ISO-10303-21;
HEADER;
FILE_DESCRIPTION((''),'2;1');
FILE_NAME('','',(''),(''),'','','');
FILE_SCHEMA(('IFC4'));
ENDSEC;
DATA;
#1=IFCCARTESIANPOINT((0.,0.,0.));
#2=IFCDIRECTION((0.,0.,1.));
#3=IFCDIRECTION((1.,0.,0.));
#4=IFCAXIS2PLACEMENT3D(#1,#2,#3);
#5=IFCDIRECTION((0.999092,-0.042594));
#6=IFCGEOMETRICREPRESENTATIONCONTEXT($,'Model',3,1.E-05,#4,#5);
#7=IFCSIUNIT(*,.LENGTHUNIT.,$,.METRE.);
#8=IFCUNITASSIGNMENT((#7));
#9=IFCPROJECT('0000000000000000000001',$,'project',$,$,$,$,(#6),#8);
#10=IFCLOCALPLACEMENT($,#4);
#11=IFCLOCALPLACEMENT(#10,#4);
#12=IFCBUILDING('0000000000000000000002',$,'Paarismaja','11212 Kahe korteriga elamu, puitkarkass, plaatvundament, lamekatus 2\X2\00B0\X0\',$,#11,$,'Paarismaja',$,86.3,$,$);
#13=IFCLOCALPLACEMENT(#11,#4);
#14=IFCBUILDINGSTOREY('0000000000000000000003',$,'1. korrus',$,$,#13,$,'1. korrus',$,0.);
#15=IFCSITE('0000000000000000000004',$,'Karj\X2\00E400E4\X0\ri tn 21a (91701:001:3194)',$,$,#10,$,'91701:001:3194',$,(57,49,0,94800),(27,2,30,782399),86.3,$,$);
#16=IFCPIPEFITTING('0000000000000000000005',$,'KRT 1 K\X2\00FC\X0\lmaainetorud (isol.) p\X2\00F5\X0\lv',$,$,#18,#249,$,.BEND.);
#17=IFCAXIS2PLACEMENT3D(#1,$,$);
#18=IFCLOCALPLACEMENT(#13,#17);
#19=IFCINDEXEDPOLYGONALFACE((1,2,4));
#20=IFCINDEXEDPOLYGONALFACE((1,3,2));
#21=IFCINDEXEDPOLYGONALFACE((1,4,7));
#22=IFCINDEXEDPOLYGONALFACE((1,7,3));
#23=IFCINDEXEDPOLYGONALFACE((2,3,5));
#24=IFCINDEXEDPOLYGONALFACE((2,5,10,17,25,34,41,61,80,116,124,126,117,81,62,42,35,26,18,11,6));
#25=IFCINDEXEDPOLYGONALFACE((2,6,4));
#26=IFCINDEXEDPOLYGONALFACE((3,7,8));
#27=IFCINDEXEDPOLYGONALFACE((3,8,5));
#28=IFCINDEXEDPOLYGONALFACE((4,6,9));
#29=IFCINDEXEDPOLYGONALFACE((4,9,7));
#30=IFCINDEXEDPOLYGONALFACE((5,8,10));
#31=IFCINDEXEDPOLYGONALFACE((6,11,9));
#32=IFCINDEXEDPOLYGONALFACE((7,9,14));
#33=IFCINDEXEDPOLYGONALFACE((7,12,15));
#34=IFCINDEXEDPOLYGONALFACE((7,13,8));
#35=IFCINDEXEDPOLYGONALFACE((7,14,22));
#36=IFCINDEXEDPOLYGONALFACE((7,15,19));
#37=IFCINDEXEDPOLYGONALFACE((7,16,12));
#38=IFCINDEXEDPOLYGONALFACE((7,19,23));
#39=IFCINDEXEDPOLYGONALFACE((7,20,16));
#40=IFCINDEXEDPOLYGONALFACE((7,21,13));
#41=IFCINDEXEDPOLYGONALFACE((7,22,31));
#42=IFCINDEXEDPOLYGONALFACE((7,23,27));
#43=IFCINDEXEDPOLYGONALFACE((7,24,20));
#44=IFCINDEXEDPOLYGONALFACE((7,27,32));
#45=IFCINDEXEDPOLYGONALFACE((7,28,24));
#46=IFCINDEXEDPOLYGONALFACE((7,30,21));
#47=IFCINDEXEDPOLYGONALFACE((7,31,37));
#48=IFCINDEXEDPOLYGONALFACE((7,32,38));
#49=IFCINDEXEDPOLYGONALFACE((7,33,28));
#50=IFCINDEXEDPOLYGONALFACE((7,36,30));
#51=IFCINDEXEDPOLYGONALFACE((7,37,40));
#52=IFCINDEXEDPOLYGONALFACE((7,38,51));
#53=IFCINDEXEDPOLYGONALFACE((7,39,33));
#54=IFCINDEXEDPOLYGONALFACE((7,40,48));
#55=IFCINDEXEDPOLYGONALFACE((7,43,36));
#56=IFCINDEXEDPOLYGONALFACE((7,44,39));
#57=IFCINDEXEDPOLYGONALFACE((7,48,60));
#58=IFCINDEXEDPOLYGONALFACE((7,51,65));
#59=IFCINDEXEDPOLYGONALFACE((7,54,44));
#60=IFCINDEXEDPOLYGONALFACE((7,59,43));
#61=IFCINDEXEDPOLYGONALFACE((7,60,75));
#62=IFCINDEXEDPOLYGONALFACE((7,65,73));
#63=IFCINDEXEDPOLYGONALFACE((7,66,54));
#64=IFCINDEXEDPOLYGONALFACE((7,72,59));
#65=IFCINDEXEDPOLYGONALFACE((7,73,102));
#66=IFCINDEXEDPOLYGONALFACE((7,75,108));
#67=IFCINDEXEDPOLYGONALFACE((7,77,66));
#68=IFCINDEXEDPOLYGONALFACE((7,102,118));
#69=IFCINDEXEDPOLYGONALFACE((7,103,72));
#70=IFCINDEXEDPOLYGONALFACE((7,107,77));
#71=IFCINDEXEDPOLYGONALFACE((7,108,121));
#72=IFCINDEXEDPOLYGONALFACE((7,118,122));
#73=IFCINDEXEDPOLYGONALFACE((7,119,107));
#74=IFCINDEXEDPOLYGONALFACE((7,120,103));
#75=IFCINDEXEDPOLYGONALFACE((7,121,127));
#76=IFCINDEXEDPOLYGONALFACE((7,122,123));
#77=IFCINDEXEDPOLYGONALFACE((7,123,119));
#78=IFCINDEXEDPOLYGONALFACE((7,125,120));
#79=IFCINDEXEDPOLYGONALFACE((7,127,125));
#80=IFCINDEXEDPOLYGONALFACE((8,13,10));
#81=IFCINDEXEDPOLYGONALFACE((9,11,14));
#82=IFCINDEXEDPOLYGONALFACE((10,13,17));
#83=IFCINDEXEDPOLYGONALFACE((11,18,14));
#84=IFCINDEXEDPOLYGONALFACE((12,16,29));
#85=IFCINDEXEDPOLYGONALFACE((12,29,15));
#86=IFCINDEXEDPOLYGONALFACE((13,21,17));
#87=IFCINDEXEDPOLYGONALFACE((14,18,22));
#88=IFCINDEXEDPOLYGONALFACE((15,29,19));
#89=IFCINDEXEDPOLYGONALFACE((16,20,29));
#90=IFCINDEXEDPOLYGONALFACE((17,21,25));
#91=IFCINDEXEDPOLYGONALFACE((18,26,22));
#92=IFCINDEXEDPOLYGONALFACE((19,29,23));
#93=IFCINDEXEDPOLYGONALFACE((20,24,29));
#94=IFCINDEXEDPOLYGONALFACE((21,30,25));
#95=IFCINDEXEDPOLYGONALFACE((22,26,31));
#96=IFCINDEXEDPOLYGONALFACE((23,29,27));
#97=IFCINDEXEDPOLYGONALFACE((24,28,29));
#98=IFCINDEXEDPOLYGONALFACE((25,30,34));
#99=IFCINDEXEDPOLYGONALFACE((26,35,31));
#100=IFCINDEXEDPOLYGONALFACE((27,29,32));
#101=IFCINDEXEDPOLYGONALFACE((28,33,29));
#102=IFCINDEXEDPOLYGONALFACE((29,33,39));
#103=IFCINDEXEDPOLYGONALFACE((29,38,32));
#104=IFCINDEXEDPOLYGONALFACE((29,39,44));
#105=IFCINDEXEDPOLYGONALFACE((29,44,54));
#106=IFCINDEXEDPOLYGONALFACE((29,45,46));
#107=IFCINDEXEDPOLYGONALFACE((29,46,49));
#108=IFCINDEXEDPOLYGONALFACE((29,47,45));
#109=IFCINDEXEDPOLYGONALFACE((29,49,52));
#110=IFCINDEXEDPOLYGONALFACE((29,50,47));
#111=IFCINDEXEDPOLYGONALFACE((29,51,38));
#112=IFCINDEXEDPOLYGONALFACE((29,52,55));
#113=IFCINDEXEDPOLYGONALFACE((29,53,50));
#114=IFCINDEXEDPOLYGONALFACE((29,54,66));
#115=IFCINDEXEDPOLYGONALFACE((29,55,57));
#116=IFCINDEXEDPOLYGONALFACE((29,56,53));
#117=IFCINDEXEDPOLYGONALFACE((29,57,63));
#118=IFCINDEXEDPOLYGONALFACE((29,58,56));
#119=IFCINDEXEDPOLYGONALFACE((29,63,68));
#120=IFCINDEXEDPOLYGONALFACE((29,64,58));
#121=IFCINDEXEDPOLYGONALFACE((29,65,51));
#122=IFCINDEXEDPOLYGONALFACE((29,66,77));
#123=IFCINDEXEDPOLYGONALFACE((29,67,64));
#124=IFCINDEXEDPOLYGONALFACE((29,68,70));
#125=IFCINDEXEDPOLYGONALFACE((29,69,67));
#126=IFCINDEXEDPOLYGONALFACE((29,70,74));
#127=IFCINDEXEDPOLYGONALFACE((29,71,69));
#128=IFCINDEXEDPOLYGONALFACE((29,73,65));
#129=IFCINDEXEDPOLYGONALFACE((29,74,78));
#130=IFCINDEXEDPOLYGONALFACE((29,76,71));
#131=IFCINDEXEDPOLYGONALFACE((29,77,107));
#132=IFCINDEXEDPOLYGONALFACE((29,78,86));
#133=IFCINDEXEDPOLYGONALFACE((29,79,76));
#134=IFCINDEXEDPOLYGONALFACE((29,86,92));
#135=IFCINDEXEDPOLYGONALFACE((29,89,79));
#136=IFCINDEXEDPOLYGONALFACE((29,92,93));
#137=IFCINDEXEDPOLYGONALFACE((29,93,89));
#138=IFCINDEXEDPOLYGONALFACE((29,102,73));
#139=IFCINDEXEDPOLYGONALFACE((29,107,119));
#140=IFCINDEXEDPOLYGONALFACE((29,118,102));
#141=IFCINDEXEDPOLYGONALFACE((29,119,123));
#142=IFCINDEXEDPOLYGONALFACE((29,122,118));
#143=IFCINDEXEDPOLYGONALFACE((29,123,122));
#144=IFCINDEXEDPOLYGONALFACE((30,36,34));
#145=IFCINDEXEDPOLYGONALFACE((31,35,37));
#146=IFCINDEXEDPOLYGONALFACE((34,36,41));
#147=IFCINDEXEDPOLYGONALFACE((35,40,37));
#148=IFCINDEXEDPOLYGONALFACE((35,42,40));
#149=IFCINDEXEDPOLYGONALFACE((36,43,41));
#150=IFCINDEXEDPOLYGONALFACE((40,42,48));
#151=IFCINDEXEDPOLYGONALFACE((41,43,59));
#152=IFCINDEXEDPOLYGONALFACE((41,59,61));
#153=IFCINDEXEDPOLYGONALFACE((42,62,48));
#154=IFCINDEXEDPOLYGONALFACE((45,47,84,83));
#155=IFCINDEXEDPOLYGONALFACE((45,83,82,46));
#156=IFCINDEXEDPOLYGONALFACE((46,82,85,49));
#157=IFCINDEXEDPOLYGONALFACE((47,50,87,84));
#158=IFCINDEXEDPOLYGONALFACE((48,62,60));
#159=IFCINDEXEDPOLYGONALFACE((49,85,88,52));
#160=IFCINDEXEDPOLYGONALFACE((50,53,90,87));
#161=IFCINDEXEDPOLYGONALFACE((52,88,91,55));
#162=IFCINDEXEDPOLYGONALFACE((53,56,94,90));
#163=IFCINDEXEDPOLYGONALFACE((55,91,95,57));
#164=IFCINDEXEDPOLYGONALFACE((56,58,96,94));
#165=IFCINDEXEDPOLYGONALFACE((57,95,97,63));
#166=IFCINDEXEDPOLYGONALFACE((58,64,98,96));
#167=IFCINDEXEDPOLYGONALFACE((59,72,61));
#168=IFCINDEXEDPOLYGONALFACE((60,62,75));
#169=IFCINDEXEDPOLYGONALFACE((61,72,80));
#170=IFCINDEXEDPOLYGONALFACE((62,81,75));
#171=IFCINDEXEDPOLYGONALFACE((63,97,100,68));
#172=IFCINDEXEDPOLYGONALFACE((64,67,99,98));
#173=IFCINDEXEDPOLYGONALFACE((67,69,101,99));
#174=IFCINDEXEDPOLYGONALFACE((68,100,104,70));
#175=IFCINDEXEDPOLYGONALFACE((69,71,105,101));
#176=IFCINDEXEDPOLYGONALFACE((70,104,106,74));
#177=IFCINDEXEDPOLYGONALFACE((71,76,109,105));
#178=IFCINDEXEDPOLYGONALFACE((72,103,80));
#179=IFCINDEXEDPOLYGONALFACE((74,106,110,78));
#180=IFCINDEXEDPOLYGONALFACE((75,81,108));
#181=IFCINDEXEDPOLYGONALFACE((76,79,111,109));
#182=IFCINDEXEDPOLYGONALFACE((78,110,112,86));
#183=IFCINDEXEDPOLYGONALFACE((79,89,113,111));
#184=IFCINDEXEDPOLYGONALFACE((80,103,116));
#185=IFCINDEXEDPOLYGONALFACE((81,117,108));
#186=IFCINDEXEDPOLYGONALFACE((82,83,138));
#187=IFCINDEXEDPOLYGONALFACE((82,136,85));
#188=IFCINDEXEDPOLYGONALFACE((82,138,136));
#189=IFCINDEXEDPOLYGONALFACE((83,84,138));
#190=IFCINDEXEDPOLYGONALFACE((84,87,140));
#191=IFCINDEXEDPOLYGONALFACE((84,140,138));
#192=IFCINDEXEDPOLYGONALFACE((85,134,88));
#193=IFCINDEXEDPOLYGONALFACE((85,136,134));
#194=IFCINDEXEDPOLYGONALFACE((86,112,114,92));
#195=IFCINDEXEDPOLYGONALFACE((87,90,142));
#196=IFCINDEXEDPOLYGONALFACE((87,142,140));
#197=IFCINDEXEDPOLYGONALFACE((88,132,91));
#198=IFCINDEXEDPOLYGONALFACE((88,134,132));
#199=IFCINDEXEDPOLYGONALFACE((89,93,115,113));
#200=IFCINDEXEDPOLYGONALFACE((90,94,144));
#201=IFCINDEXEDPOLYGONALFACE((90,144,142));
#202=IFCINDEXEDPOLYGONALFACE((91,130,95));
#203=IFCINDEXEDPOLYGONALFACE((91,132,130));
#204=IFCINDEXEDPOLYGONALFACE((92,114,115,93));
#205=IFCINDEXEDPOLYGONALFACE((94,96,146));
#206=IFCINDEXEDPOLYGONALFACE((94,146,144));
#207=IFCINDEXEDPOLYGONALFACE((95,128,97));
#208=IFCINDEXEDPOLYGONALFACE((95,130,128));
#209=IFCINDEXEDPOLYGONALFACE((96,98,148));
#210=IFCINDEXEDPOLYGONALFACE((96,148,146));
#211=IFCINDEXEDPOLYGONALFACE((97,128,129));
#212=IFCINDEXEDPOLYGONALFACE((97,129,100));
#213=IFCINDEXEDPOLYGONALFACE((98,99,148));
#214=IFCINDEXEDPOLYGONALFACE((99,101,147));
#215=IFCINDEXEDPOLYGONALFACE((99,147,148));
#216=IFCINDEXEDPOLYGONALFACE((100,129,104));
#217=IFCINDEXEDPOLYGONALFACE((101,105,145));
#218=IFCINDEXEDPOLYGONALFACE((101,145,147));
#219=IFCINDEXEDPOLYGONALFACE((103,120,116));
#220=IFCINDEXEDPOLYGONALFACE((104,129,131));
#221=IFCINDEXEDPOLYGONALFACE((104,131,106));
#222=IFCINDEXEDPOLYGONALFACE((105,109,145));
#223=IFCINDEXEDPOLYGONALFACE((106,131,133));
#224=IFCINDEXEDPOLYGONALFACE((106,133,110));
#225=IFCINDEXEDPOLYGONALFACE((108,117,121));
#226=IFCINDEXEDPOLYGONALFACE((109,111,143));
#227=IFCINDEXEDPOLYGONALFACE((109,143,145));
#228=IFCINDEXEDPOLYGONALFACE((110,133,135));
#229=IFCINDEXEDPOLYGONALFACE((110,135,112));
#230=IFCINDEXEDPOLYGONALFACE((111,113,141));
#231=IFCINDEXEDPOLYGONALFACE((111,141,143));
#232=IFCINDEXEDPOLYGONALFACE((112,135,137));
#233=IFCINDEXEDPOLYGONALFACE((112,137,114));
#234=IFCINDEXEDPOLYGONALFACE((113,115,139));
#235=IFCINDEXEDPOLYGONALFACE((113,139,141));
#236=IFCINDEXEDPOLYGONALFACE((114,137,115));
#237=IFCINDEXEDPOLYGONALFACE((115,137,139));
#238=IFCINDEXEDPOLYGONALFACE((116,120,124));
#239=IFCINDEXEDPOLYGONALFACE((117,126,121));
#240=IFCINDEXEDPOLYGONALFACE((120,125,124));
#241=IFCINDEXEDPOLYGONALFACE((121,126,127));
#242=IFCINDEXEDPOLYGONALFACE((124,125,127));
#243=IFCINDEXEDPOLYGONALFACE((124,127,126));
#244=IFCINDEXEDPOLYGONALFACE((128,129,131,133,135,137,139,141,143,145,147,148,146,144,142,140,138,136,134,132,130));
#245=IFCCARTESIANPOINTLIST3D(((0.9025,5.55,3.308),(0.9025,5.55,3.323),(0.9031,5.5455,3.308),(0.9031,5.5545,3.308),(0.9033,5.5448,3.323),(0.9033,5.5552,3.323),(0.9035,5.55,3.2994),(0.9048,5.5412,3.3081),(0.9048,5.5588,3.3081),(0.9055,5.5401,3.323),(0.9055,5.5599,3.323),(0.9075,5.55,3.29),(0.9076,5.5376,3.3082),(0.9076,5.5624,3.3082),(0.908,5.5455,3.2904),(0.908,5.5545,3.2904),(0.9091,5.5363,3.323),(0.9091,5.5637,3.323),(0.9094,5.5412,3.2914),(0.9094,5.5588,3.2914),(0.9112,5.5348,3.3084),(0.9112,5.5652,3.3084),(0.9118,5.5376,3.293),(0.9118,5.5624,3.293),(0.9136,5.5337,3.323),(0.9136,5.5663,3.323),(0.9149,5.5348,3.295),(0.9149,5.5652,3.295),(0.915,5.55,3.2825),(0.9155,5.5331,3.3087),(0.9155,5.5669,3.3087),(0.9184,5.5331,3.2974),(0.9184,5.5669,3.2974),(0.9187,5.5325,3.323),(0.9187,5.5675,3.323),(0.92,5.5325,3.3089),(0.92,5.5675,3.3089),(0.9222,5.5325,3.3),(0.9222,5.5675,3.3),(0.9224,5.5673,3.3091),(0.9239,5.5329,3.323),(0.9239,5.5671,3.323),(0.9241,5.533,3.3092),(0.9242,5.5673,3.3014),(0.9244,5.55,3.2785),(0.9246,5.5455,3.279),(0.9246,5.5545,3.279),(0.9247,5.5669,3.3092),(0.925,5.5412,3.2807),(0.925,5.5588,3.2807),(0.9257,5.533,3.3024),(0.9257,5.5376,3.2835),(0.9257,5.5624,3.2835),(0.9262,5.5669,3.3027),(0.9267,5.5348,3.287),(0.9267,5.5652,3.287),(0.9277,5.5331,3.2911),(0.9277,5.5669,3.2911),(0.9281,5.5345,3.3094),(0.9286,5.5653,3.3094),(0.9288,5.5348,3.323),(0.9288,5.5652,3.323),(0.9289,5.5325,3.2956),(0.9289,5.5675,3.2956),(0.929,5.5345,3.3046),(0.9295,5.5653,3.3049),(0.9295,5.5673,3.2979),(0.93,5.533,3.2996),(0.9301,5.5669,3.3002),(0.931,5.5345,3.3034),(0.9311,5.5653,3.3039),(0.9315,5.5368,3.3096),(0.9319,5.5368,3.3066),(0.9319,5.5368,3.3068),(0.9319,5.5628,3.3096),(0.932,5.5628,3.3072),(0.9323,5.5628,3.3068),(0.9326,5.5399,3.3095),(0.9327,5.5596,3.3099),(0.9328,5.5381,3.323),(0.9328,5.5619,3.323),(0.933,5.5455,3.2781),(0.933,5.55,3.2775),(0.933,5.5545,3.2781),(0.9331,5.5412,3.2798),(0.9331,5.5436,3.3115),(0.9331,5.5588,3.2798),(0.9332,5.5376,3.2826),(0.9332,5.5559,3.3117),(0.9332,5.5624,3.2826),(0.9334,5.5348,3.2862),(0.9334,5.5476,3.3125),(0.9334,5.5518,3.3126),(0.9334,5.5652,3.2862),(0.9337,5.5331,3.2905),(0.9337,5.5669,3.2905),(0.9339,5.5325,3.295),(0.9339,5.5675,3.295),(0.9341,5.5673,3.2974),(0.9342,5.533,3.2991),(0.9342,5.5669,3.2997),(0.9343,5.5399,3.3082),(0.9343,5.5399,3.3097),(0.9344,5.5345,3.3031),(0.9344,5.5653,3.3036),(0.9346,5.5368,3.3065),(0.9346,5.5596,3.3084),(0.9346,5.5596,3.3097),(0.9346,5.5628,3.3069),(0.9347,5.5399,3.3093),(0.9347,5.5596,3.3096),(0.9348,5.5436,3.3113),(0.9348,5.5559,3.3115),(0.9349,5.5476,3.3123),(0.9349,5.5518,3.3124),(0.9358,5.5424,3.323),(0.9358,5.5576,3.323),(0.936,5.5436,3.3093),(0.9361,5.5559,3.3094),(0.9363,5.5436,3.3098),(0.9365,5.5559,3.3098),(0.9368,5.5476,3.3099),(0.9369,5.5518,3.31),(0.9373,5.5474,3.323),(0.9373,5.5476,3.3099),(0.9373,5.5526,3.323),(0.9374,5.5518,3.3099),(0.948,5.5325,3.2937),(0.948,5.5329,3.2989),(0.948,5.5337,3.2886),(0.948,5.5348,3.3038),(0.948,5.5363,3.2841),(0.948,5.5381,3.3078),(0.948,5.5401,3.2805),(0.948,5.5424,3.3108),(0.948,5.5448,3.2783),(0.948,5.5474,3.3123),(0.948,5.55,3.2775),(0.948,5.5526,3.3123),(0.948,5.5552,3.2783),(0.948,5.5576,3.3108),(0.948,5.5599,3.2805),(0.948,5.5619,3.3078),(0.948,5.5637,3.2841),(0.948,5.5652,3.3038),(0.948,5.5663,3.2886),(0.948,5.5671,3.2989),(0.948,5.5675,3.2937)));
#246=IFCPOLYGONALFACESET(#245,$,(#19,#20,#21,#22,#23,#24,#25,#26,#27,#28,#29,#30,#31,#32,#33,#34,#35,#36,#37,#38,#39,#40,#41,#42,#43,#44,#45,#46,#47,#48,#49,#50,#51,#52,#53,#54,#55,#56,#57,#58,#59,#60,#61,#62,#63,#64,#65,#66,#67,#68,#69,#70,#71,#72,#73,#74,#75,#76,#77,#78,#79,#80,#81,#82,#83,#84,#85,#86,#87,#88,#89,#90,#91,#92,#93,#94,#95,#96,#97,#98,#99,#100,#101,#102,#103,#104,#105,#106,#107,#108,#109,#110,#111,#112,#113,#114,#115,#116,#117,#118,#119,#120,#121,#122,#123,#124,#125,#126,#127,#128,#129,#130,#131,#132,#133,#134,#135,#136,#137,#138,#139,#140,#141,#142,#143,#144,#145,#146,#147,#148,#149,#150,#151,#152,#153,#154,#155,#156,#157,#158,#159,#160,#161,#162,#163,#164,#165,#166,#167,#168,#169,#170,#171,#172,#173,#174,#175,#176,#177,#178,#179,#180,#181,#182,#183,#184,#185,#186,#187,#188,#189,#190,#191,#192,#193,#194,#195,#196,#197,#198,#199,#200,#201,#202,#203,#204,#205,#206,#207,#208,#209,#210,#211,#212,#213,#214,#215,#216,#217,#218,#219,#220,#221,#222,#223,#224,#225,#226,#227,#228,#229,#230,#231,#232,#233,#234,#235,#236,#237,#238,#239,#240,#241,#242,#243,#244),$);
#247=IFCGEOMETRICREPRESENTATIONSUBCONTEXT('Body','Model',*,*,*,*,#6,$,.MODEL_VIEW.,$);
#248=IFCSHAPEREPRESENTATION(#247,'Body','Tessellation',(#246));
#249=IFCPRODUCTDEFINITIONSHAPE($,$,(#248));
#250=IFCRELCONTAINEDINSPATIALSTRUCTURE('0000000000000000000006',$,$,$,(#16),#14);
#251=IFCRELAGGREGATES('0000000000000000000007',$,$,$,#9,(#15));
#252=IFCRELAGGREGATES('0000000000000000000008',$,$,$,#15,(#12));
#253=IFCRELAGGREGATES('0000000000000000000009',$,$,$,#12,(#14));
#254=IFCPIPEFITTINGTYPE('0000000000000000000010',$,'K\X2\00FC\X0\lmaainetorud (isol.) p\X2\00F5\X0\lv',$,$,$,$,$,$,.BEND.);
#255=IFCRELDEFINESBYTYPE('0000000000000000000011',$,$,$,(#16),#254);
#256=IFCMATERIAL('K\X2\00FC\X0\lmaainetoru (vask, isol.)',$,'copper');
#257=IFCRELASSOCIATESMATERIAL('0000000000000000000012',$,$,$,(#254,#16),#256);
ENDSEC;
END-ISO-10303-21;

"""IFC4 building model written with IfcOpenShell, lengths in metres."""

from ifc_helpers import new_model, entity, si_unit, direction, frame, origin_with_axes, place, context, subcontext, project, spatial, material, type_object, element, save


model = new_model("IFC4")

# Units and contexts
model_context = context("Model", 3, precision=1e-05, world=origin_with_axes(), true_north=direction((0.999092, -0.042594)))
body_context = subcontext(model_context, "Body", "Model", "MODEL_VIEW")
ifc_project = project(units=[si_unit("LENGTHUNIT", "METRE")], contexts=[model_context])

# Site, building, storey
site_placement = place(None, origin_with_axes())
site = spatial("IfcSite", under=ifc_project, at=site_placement, Name="Karjääri tn 21a (91701:001:3194)", LongName="91701:001:3194", RefLatitude=(57, 49, 0, 94800), RefLongitude=(27, 2, 30, 782399), RefElevation=86.3)
building_placement = place(site_placement, origin_with_axes())
building = spatial("IfcBuilding", under=site, at=building_placement, Name="Paarismaja", Description="11212 Kahe korteriga elamu, puitkarkass, plaatvundament, lamekatus 2°", LongName="Paarismaja", ElevationOfRefHeight=86.3)
storey_placement = place(building_placement, origin_with_axes())
storey = spatial("IfcBuildingStorey", under=building, at=storey_placement, Name="1. korrus", LongName="1. korrus", Elevation=0.0)

# Pipe fitting
ifc_material_1 = material(Name="Külmaainetoru (vask, isol.)", Category="copper")
pipe_fitting_type_1 = type_object("IfcPipeFittingType", Name="Külmaainetorud (isol.) põlv", PredefinedType="BEND", material=ifc_material_1)
pipe_fitting_1_placement = place(storey_placement, frame((0.92, 5.55, 3.295), z_axis=(0.0, 0.0, 1.0), x_axis=(1.0, 0.0, 0.0)))
element("IfcPipeFitting", 1, at=pipe_fitting_1_placement, inside=storey, type_object=pipe_fitting_type_1, material=ifc_material_1, Name="KRT 1 Külmaainetorud (isol.) põlv", PredefinedType="BEND", context=body_context, shape_type="AdvancedSweptSolid", body=[
    entity("IfcSweptDiskSolid", entity("IfcIndexedPolyCurve", entity("IfcCartesianPointList3D", [[0.028, 0.0, 0.0], [0.0139, 0.0, 0.0], [0.0089, 0.0, 0.0006], [0.005, 0.0, 0.0022], [0.0022, 0.0, 0.005], [0.0006, 0.0, 0.0089], [0.0, 0.0, 0.0139], [0.0, 0.0, 0.028]]), None, False), 0.0175),
])

save(model, "model.ifc")
